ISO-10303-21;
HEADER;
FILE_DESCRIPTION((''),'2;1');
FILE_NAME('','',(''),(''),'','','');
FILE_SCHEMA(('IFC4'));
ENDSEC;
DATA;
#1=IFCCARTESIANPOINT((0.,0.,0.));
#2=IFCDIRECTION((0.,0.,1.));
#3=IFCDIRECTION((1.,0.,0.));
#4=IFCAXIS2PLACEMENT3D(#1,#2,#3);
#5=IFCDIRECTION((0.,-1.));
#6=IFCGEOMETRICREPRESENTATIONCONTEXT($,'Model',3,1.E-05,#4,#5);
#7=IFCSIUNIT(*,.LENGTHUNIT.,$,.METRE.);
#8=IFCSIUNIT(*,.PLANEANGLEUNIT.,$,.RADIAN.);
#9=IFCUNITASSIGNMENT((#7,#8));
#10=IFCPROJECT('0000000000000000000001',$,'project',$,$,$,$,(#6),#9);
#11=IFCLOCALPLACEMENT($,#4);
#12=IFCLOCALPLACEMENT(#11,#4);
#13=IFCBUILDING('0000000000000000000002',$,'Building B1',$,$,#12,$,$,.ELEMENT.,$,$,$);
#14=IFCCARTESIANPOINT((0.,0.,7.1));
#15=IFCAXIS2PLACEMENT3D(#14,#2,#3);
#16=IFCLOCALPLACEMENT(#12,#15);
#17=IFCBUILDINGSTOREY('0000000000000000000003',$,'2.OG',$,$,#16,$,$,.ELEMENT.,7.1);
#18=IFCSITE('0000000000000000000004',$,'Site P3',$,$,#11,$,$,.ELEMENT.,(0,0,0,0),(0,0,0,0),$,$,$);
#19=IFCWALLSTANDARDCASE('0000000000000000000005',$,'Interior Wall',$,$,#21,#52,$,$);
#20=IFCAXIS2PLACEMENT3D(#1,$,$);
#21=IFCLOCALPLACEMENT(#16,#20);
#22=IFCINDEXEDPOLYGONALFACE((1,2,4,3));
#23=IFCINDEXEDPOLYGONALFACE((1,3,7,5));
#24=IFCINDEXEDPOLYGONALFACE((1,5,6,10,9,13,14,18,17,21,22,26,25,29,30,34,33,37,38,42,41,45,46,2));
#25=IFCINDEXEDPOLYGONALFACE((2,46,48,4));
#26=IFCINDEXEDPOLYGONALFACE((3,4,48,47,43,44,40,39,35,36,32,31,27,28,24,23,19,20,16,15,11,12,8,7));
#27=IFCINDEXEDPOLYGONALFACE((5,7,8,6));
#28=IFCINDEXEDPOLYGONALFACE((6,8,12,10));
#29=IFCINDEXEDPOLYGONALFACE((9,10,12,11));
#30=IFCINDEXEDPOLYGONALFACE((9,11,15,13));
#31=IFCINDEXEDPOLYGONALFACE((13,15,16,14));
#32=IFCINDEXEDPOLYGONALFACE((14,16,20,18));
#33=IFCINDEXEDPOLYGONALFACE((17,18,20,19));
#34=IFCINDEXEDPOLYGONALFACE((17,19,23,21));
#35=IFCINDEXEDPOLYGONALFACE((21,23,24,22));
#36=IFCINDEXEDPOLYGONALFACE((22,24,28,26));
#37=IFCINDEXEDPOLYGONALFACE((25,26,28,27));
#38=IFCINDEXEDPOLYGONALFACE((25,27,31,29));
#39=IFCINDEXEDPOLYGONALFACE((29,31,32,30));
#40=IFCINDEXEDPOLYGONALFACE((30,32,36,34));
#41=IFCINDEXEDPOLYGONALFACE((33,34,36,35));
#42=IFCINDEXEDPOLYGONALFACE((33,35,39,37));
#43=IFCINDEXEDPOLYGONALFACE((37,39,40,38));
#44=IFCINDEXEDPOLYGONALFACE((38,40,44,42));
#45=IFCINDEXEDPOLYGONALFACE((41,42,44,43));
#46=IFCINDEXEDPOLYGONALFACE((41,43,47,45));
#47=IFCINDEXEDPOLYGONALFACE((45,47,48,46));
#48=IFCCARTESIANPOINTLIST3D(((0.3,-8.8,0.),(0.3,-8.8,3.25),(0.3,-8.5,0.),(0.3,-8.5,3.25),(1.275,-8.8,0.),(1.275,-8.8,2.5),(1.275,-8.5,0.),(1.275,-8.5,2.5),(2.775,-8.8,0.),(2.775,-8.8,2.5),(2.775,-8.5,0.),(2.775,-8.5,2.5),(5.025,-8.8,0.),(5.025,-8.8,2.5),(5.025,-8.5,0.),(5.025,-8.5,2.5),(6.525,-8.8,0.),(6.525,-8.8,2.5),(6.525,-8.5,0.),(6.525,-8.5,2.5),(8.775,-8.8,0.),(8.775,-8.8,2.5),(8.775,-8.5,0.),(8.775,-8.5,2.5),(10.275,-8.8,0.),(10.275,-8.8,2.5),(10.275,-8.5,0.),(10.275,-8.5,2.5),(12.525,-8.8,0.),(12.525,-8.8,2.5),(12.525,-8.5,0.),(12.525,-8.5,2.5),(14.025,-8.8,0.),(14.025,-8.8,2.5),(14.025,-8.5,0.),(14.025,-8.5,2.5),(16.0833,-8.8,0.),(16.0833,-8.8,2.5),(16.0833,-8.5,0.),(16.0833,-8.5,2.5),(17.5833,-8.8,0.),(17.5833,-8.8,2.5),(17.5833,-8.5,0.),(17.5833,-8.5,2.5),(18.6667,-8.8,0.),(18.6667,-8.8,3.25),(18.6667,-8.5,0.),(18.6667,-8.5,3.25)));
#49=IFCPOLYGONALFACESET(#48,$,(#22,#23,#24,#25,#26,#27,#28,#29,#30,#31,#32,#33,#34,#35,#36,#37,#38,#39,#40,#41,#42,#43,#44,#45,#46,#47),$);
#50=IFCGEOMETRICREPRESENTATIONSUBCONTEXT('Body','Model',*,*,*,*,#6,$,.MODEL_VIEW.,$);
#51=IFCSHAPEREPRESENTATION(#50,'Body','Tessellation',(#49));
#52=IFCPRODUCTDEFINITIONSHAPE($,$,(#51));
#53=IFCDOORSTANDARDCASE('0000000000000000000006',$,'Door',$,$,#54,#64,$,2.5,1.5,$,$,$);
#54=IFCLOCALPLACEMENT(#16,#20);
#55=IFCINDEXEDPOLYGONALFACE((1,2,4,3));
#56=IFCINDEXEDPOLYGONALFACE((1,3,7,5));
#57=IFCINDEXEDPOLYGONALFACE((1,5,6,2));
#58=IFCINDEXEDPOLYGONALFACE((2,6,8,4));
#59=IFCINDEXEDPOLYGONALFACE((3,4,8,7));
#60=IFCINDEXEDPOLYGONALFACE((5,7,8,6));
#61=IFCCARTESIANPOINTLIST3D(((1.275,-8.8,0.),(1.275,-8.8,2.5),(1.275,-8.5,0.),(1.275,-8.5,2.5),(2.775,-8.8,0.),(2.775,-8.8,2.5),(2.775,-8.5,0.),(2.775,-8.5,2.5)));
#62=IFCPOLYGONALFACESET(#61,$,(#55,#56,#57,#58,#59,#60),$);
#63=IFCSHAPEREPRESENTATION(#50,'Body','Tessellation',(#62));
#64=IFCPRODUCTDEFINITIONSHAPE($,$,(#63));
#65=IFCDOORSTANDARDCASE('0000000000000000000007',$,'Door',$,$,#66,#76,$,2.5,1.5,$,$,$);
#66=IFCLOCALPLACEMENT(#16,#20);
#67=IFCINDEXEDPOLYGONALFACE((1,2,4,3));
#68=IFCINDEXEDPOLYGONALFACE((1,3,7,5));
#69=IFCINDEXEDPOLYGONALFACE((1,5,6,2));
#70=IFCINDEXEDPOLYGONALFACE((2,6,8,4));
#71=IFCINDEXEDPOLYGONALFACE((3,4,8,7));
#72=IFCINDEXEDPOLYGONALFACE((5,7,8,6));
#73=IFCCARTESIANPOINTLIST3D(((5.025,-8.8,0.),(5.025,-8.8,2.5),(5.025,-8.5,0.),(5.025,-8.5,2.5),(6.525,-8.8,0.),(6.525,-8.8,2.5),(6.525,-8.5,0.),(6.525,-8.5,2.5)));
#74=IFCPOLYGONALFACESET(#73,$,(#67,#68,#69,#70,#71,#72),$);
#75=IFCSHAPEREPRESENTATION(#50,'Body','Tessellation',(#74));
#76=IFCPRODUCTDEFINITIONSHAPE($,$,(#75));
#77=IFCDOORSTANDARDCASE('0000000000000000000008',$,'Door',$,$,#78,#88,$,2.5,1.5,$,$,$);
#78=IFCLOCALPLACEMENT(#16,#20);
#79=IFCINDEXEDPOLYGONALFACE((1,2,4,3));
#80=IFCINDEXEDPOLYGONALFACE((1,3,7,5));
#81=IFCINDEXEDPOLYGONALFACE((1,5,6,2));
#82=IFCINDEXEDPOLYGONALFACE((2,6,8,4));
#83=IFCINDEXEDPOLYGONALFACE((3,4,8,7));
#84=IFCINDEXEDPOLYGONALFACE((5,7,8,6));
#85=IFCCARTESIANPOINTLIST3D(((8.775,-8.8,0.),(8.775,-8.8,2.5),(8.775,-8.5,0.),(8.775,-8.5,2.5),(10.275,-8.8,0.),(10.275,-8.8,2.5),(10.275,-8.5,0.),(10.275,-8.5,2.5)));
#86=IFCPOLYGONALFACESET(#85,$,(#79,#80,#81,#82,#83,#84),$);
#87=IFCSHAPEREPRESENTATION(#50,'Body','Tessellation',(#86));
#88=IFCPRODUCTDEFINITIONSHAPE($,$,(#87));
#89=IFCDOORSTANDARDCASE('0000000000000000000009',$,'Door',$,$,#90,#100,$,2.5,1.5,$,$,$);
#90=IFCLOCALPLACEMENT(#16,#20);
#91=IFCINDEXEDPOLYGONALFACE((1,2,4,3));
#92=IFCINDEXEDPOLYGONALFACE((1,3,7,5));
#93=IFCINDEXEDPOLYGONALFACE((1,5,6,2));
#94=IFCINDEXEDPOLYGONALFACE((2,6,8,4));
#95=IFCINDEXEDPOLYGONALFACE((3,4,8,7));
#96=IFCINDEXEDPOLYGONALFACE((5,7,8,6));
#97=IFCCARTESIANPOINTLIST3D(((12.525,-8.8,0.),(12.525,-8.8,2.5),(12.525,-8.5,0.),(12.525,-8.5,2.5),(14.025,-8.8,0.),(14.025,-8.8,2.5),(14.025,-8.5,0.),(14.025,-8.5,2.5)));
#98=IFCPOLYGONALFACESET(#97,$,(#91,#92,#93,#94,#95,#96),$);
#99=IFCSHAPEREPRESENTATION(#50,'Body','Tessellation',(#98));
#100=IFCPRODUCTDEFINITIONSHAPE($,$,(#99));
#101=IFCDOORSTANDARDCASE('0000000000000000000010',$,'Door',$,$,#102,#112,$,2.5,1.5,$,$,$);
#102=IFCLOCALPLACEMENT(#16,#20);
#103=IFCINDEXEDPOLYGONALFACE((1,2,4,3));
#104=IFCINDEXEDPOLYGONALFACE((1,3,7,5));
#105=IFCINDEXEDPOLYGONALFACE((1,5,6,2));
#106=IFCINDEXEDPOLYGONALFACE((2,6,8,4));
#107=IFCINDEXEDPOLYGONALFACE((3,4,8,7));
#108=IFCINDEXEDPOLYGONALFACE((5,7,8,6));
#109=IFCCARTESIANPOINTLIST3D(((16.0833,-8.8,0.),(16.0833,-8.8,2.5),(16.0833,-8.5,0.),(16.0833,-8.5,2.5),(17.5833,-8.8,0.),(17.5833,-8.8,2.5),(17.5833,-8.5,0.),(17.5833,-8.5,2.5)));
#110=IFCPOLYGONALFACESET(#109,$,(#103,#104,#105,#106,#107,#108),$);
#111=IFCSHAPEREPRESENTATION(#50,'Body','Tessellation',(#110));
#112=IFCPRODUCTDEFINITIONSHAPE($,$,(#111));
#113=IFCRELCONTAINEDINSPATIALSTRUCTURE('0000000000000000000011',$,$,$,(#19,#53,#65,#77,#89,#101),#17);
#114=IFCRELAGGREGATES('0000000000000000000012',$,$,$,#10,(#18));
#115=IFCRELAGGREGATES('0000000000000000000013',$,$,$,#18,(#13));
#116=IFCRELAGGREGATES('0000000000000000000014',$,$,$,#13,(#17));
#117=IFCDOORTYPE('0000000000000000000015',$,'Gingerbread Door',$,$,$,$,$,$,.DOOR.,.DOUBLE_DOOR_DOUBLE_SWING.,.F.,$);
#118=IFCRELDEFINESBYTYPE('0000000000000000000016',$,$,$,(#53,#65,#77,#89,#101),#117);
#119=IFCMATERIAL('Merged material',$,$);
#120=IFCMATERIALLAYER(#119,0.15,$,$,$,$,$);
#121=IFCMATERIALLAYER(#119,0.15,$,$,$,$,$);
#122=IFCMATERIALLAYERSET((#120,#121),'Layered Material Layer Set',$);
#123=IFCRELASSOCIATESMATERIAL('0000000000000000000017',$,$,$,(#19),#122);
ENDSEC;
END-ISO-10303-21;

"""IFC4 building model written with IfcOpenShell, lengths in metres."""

from ifc_helpers import new_model, si_unit, direction, frame, origin_with_axes, place, context, subcontext, project, spatial, polyline, outline, extrude, source, transform, mapped, material, layer, layer_set, layer_usage, type_object, element, fill, save


model = new_model("IFC4")

# Units and contexts
model_context = context("Model", 3, precision=1e-05, world=origin_with_axes(), true_north=direction((0.0, -1.0)))
body_context = subcontext(model_context, "Body", "Model", "MODEL_VIEW")
ifc_project = project(units=[si_unit("LENGTHUNIT", "METRE"), si_unit("PLANEANGLEUNIT", "RADIAN")], contexts=[model_context])

# Site, building, storey
site_placement = place(None, origin_with_axes())
site = spatial("IfcSite", under=ifc_project, at=site_placement, Name="Site P3", CompositionType="ELEMENT", RefLatitude=(0, 0, 0, 0), RefLongitude=(0, 0, 0, 0))
building_placement = place(site_placement, origin_with_axes())
building = spatial("IfcBuilding", under=site, at=building_placement, Name="Building B1", CompositionType="ELEMENT")
storey_placement = place(building_placement, frame((0.0, 0.0, 7.1), z_axis=(0.0, 0.0, 1.0), x_axis=(1.0, 0.0, 0.0)))
storey = spatial("IfcBuildingStorey", under=building, at=storey_placement, Name="2.OG", CompositionType="ELEMENT", Elevation=7.1)

# Shared definitions
ifc_material = material(Name="Merged material")

# Wall, openings, doors
ifc_layer_1 = layer(ifc_material, 0.15)
ifc_layer_2 = layer(ifc_material, 0.15)
ifc_layer_set_1 = layer_set([ifc_layer_1, ifc_layer_2], Name="Layered Material Layer Set")
ifc_layer_usage_1 = layer_usage(ifc_layer_set_1, "AXIS2", "POSITIVE", -0.15)
wall_1_placement = place(storey_placement, frame((0.3, -8.65, 0.0), z_axis=(0.0, 0.0, 1.0), x_axis=(1.0, 0.0, 0.0)))
wall_1 = element("IfcWallStandardCase", 1, at=wall_1_placement, inside=storey, material=ifc_layer_usage_1, Name="Interior Wall", context=body_context, shape_type="SweptSolid", body=[
    extrude(outline(polyline([(0.0, 0.15), (18.3667, 0.15), (18.3667, -0.15), (0.0, -0.15), (0.0, 0.15)])), origin_with_axes(), (0.0, 0.0, 1.0), 3.25),
])
opening_1_placement = place(wall_1_placement, frame((0.975, 0.0, 0.0), z_axis=(0.0, 0.0, 1.0), x_axis=(1.0, 0.0, 0.0)))
opening_1 = element("IfcOpeningStandardCase", 2, at=opening_1_placement, cuts=wall_1, context=body_context, shape_type="SweptSolid", body=[
    extrude(outline(polyline([(0.0, 0.0), (0.0, 1.5), (2.5, 1.5), (2.5, 0.0), (0.0, 0.0)])), frame((0.0, -0.15, 0.0), z_axis=(0.0, 1.0, 0.0), x_axis=(0.0, 0.0, 1.0)), (0.0, 0.0, 1.0), 0.3),
])
opening_2_placement = place(wall_1_placement, frame((4.725, 0.0, 0.0), z_axis=(0.0, 0.0, 1.0), x_axis=(1.0, 0.0, 0.0)))
opening_2 = element("IfcOpeningStandardCase", 3, at=opening_2_placement, cuts=wall_1, context=body_context, shape_type="SweptSolid", body=[
    extrude(outline(polyline([(0.0, 0.0), (0.0, 1.5), (2.5, 1.5), (2.5, 0.0), (0.0, 0.0)])), frame((0.0, -0.15, 0.0), z_axis=(0.0, 1.0, 0.0), x_axis=(0.0, 0.0, 1.0)), (0.0, 0.0, 1.0), 0.3),
])
opening_3_placement = place(wall_1_placement, frame((8.475, 0.0, 0.0), z_axis=(0.0, 0.0, 1.0), x_axis=(1.0, 0.0, 0.0)))
opening_3 = element("IfcOpeningStandardCase", 4, at=opening_3_placement, cuts=wall_1, context=body_context, shape_type="SweptSolid", body=[
    extrude(outline(polyline([(0.0, 0.0), (0.0, 1.5), (2.5, 1.5), (2.5, 0.0), (0.0, 0.0)])), frame((0.0, -0.15, 0.0), z_axis=(0.0, 1.0, 0.0), x_axis=(0.0, 0.0, 1.0)), (0.0, 0.0, 1.0), 0.3),
])
opening_4_placement = place(wall_1_placement, frame((12.225, 0.0, 0.0), z_axis=(0.0, 0.0, 1.0), x_axis=(1.0, 0.0, 0.0)))
opening_4 = element("IfcOpeningStandardCase", 5, at=opening_4_placement, cuts=wall_1, context=body_context, shape_type="SweptSolid", body=[
    extrude(outline(polyline([(0.0, 0.0), (0.0, 1.5), (2.5, 1.5), (2.5, 0.0), (0.0, 0.0)])), frame((0.0, -0.15, 0.0), z_axis=(0.0, 1.0, 0.0), x_axis=(0.0, 0.0, 1.0)), (0.0, 0.0, 1.0), 0.3),
])
opening_5_placement = place(wall_1_placement, frame((15.7833, 0.0, 0.0), z_axis=(0.0, 0.0, 1.0), x_axis=(1.0, 0.0, 0.0)))
opening_5 = element("IfcOpeningStandardCase", 6, at=opening_5_placement, cuts=wall_1, context=body_context, shape_type="SweptSolid", body=[
    extrude(outline(polyline([(0.0, 0.0), (0.0, 1.5), (2.5, 1.5), (2.5, 0.0), (0.0, 0.0)])), frame((0.0, -0.15, 0.0), z_axis=(0.0, 1.0, 0.0), x_axis=(0.0, 0.0, 1.0)), (0.0, 0.0, 1.0), 0.3),
])
door_type = type_object("IfcDoorType", Name="Gingerbread Door", OperationType="DOUBLE_DOOR_DOUBLE_SWING", ParameterTakesPrecedence=False, PredefinedType="DOOR")
shared_shape_1 = source(origin_with_axes(), body_context, "Body", "SweptSolid", [
    extrude(outline(polyline([(0.0, 0.0), (0.0, 1.5), (2.5, 1.5), (2.5, 0.0), (0.0, 0.0)])), frame((0.0, -0.15, 0.0), z_axis=(0.0, 1.0, 0.0), x_axis=(0.0, 0.0, 1.0)), (0.0, 0.0, 1.0), 0.3),
])
door_1_placement = place(opening_1_placement, origin_with_axes())
door_1 = element("IfcDoorStandardCase", 7, at=door_1_placement, inside=storey, type_object=door_type, Name="Door", OverallHeight=2.5, OverallWidth=1.5, context=body_context, shape_type="MappedRepresentation", body=[
    mapped(shared_shape_1, transform((0.0, 0.0, 0.0))),
])
fill(opening_1, door_1)
door_2_placement = place(opening_2_placement, origin_with_axes())
door_2 = element("IfcDoorStandardCase", 8, at=door_2_placement, inside=storey, type_object=door_type, Name="Door", OverallHeight=2.5, OverallWidth=1.5, context=body_context, shape_type="MappedRepresentation", body=[
    mapped(shared_shape_1, transform((0.0, 0.0, 0.0))),
])
fill(opening_2, door_2)
door_3_placement = place(opening_3_placement, origin_with_axes())
door_3 = element("IfcDoorStandardCase", 9, at=door_3_placement, inside=storey, type_object=door_type, Name="Door", OverallHeight=2.5, OverallWidth=1.5, context=body_context, shape_type="MappedRepresentation", body=[
    mapped(shared_shape_1, transform((0.0, 0.0, 0.0))),
])
fill(opening_3, door_3)
door_4_placement = place(opening_4_placement, origin_with_axes())
door_4 = element("IfcDoorStandardCase", 10, at=door_4_placement, inside=storey, type_object=door_type, Name="Door", OverallHeight=2.5, OverallWidth=1.5, context=body_context, shape_type="MappedRepresentation", body=[
    mapped(shared_shape_1, transform((0.0, 0.0, 0.0))),
])
fill(opening_4, door_4)
door_5_placement = place(opening_5_placement, origin_with_axes())
door_5 = element("IfcDoorStandardCase", 11, at=door_5_placement, inside=storey, type_object=door_type, Name="Door", OverallHeight=2.5, OverallWidth=1.5, context=body_context, shape_type="MappedRepresentation", body=[
    mapped(shared_shape_1, transform((0.0, 0.0, 0.0))),
])
fill(opening_5, door_5)

save(model, "model.ifc")
